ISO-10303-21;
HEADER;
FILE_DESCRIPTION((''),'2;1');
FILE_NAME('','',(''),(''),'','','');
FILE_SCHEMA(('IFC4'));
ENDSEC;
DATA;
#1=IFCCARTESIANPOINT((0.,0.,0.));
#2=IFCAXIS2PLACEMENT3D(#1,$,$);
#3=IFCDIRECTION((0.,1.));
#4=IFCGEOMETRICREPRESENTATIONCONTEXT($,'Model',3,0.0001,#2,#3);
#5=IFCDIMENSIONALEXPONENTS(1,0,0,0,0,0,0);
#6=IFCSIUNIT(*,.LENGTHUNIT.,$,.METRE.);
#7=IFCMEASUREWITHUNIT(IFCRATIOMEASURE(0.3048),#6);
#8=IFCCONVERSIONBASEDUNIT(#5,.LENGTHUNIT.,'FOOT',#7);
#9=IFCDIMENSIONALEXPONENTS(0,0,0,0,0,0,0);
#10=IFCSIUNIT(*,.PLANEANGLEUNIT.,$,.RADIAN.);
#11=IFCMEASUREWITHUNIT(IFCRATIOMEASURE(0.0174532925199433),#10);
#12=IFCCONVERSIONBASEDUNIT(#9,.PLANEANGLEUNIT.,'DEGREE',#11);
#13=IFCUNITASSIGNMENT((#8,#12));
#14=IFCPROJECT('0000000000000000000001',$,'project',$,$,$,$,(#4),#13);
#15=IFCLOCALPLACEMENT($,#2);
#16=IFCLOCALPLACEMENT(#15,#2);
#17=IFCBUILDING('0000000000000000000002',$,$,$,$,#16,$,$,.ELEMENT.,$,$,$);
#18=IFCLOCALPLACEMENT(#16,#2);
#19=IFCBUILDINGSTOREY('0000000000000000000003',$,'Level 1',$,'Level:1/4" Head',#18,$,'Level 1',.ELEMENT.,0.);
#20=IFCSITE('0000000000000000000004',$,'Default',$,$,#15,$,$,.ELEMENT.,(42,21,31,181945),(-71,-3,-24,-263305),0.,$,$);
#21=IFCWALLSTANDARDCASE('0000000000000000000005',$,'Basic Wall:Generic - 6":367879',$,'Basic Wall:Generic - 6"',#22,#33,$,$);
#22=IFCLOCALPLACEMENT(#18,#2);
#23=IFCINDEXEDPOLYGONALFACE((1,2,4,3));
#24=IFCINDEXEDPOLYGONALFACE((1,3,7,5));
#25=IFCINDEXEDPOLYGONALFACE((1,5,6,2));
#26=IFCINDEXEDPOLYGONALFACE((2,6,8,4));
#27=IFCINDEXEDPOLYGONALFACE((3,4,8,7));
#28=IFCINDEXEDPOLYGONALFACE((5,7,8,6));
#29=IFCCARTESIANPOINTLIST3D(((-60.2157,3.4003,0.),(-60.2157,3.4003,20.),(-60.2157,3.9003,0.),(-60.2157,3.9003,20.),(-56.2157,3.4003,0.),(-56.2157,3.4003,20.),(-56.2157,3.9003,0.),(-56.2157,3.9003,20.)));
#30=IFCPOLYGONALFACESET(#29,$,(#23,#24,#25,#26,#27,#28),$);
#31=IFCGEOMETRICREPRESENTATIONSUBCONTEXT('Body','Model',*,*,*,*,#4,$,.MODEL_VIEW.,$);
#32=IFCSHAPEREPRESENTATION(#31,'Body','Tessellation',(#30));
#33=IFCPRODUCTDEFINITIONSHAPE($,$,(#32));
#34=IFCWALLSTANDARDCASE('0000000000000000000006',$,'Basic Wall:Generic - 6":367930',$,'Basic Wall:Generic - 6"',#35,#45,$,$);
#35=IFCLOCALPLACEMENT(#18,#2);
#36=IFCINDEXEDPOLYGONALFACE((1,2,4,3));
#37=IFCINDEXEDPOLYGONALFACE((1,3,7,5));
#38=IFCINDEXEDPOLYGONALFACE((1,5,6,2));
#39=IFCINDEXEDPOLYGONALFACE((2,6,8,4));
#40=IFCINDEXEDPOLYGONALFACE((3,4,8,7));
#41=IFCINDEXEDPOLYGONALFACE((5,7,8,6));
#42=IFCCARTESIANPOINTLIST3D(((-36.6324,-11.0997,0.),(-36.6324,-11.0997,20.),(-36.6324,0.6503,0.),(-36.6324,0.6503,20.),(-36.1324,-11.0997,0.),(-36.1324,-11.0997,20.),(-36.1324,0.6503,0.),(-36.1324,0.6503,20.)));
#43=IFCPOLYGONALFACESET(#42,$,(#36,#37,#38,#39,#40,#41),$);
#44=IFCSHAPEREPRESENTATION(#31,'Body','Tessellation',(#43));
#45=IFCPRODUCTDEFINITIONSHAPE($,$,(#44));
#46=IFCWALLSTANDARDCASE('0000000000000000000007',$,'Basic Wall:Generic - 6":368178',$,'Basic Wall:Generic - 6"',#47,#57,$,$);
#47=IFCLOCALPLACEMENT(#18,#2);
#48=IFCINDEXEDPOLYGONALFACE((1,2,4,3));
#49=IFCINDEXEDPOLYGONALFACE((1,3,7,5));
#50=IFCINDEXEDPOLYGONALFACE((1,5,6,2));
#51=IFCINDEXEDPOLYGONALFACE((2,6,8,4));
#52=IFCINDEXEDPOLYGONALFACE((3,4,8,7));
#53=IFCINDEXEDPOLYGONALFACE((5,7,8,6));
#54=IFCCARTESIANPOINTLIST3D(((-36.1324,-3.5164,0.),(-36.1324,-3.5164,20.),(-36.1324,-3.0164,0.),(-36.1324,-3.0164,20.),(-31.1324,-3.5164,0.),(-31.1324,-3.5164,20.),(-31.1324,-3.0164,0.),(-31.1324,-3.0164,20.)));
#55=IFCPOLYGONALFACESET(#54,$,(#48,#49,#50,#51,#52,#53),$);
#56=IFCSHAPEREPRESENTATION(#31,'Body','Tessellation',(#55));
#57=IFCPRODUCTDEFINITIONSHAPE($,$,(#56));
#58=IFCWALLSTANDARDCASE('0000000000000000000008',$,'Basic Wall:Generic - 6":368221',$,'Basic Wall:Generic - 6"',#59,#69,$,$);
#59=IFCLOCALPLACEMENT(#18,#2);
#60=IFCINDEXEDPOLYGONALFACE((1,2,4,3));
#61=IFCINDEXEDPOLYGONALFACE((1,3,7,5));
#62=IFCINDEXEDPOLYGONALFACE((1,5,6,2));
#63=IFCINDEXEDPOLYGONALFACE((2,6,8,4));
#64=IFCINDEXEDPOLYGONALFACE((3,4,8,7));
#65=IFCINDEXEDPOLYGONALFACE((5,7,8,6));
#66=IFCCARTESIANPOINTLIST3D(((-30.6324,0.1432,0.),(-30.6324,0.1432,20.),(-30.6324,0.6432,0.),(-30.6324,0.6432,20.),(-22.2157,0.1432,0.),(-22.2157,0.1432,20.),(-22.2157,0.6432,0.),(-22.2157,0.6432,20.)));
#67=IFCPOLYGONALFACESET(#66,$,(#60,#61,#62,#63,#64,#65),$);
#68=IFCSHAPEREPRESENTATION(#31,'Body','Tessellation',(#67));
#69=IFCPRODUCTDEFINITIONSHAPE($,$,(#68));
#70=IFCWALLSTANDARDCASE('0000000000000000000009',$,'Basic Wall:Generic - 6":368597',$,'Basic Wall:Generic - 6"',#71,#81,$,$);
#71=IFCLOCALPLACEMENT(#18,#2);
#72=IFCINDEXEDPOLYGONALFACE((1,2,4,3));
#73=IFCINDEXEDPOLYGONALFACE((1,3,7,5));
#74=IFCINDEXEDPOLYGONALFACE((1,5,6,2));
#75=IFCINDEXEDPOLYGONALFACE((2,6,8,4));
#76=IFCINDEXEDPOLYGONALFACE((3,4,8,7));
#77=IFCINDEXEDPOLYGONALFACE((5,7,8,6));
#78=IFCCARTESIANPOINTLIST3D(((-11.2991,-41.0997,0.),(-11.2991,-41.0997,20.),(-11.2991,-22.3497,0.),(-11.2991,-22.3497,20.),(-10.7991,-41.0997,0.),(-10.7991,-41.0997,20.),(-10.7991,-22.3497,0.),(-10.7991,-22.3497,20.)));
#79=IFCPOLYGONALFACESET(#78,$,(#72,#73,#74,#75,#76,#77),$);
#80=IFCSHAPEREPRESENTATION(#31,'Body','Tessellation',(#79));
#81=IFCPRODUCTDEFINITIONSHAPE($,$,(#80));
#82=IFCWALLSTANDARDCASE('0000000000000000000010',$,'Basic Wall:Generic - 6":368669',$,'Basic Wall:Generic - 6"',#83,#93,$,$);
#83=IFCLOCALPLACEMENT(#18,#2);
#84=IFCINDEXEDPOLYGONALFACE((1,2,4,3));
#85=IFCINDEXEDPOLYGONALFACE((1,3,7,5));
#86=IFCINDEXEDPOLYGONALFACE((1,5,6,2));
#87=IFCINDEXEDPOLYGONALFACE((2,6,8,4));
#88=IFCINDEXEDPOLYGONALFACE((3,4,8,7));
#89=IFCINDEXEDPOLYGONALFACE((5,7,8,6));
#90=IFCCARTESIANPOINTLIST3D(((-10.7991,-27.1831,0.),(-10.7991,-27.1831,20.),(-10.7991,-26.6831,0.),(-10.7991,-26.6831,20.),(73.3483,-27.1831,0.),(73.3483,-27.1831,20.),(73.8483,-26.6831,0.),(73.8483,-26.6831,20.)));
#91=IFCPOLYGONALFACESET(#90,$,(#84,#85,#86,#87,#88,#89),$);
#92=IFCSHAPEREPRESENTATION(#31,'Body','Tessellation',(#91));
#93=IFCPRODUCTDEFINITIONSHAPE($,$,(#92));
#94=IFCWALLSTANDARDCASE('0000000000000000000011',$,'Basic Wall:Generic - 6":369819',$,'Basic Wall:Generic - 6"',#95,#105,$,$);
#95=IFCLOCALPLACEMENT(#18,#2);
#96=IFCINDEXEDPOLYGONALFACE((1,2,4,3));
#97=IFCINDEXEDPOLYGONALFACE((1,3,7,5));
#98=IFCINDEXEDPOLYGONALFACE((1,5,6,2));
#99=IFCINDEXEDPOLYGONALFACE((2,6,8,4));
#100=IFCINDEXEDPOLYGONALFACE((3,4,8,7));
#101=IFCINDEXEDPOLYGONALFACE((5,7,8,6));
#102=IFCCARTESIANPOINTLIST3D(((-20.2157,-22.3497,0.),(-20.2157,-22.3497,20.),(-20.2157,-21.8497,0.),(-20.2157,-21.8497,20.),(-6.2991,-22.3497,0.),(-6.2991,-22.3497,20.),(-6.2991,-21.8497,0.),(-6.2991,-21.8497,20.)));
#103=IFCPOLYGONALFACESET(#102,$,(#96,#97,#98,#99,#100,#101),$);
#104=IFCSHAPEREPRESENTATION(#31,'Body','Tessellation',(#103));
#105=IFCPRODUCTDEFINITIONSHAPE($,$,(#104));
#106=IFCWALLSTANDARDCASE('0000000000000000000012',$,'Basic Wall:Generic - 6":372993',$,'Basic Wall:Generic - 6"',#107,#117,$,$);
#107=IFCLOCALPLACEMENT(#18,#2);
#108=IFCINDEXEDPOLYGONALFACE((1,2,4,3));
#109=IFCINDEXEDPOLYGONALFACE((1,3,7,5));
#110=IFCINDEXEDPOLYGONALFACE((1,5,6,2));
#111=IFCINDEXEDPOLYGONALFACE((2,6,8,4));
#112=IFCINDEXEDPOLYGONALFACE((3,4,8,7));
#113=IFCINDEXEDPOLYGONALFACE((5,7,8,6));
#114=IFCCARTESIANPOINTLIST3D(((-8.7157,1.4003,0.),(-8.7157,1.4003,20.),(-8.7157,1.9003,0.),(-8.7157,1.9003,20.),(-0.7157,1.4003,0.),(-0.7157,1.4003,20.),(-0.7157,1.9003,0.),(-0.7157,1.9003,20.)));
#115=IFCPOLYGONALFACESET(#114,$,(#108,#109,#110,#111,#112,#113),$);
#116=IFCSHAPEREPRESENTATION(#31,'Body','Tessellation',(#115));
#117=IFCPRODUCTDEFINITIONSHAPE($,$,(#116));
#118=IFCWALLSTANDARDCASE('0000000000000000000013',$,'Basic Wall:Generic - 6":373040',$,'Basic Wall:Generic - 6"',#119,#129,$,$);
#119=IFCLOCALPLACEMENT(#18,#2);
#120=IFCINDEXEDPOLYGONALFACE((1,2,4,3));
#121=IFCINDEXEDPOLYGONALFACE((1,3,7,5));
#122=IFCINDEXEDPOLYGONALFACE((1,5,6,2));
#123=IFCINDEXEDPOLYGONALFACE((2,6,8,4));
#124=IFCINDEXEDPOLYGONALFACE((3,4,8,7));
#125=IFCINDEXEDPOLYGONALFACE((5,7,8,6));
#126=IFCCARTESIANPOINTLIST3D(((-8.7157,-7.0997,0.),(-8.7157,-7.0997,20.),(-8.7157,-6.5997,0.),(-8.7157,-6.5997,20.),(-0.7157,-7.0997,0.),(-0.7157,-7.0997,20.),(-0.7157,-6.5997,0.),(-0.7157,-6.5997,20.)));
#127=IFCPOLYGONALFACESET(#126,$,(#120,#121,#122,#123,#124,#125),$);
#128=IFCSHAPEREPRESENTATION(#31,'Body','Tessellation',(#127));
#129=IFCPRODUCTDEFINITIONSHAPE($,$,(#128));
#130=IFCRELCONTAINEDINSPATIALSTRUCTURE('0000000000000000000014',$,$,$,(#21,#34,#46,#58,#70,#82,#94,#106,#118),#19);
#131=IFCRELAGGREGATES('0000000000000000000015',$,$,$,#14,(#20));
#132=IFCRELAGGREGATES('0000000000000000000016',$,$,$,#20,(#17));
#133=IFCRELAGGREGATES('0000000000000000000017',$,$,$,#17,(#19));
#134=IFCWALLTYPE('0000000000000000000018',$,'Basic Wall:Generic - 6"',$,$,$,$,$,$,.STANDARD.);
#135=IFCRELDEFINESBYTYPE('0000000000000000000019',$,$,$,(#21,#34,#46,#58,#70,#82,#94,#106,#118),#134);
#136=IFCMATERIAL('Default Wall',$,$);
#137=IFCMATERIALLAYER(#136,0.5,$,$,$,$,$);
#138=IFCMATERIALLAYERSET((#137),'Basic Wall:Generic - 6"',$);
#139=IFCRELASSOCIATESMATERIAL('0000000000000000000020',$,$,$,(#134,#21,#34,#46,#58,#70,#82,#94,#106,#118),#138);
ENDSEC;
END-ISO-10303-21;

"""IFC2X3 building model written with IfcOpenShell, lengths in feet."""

from ifc_helpers import new_model, entity, si_unit, converted_unit, direction, frame, frame_2d, origin, place, context, subcontext, project, spatial, polyline, rectangle, outline, extrude, material, layer, layer_set, layer_usage, type_object, element, save


model = new_model("IFC2X3")

# Units and contexts
model_context = context("Model", 3, precision=0.0001, world=origin(), true_north=direction((0.0, 1.0)))
body_context = subcontext(model_context, "Body", "Model", "MODEL_VIEW")
ifc_project = project(units=[converted_unit("LENGTHUNIT", "FOOT", entity("IfcRatioMeasure", 0.3048), si_unit("LENGTHUNIT", "METRE"), dimensions=[1, 0, 0, 0, 0, 0, 0]), converted_unit("PLANEANGLEUNIT", "DEGREE", entity("IfcRatioMeasure", 0.0174532925199433), si_unit("PLANEANGLEUNIT", "RADIAN"), dimensions=[0, 0, 0, 0, 0, 0, 0])], contexts=[model_context])

# Site, building, storey
site_placement = place(None, origin())
site = spatial("IfcSite", under=ifc_project, at=site_placement, Name="Default", CompositionType="ELEMENT", RefLatitude=(42, 21, 31, 181945), RefLongitude=(-71, -3, -24, -263305), RefElevation=0.0)
building_placement = place(site_placement, origin())
building = spatial("IfcBuilding", under=site, at=building_placement, CompositionType="ELEMENT")
storey_placement = place(building_placement, origin())
storey = spatial("IfcBuildingStorey", under=building, at=storey_placement, Name="Level 1", ObjectType="Level:1/4\" Head", LongName="Level 1", CompositionType="ELEMENT", Elevation=0.0)

# Walls
ifc_material = material(Name="Default Wall")
ifc_layer_1 = layer(ifc_material, 0.5)
ifc_layer_set_1 = layer_set([ifc_layer_1], Name="Basic Wall:Generic - 6\"")
wall_type_1 = type_object("IfcWallType", Name="Basic Wall:Generic - 6\"", PredefinedType="STANDARD", material=ifc_layer_set_1)
ifc_layer_usage_1 = layer_usage(ifc_layer_set_1, "AXIS2", "NEGATIVE", 0.25)
wall_1_placement = place(storey_placement, frame((-60.2157, 3.6503, 0.0)))
element("IfcWallStandardCase", 1, at=wall_1_placement, inside=storey, type_object=wall_type_1, material=ifc_layer_usage_1, Name="Basic Wall:Generic - 6\":367879", ObjectType="Basic Wall:Generic - 6\"", context=body_context, shape_type="SweptSolid", body=[
    extrude(rectangle(XDim=4.0, YDim=0.5, at=frame_2d((2.0, 0.0), x_axis=(-1.0, 0.0))), origin(), (0.0, 0.0, 1.0), 20.0),
])
ifc_layer_usage_2 = layer_usage(ifc_layer_set_1, "AXIS2", "NEGATIVE", 0.25)
wall_2_placement = place(storey_placement, frame((-36.3824, -11.0997, 0.0), z_axis=(0.0, 0.0, 1.0), x_axis=(0.0, 1.0, 0.0)))
element("IfcWallStandardCase", 2, at=wall_2_placement, inside=storey, type_object=wall_type_1, material=ifc_layer_usage_2, Name="Basic Wall:Generic - 6\":367930", ObjectType="Basic Wall:Generic - 6\"", context=body_context, shape_type="SweptSolid", body=[
    extrude(rectangle(XDim=11.75, YDim=0.5, at=frame_2d((5.875, 0.0), x_axis=(-1.0, 0.0))), origin(), (0.0, 0.0, 1.0), 20.0),
])
ifc_layer_usage_3 = layer_usage(ifc_layer_set_1, "AXIS2", "NEGATIVE", 0.25)
wall_3_placement = place(storey_placement, frame((-31.1324, -3.2664, 0.0), z_axis=(0.0, 0.0, 1.0), x_axis=(-1.0, 0.0, 0.0)))
element("IfcWallStandardCase", 3, at=wall_3_placement, inside=storey, type_object=wall_type_1, material=ifc_layer_usage_3, Name="Basic Wall:Generic - 6\":368178", ObjectType="Basic Wall:Generic - 6\"", context=body_context, shape_type="SweptSolid", body=[
    extrude(rectangle(XDim=5.0, YDim=0.5, at=frame_2d((2.5, 0.0), x_axis=(-1.0, 0.0))), origin(), (0.0, 0.0, 1.0), 20.0),
])
ifc_layer_usage_4 = layer_usage(ifc_layer_set_1, "AXIS2", "NEGATIVE", 0.25)
wall_4_placement = place(storey_placement, frame((-30.6324, 0.3932, 0.0)))
element("IfcWallStandardCase", 4, at=wall_4_placement, inside=storey, type_object=wall_type_1, material=ifc_layer_usage_4, Name="Basic Wall:Generic - 6\":368221", ObjectType="Basic Wall:Generic - 6\"", context=body_context, shape_type="SweptSolid", body=[
    extrude(rectangle(XDim=8.4167, YDim=0.5, at=frame_2d((4.2083, 0.0), x_axis=(-1.0, 0.0))), origin(), (0.0, 0.0, 1.0), 20.0),
])
ifc_layer_usage_5 = layer_usage(ifc_layer_set_1, "AXIS2", "NEGATIVE", 0.25)
wall_5_placement = place(storey_placement, frame((-11.0491, -41.0997, 0.0), z_axis=(0.0, 0.0, 1.0), x_axis=(0.0, 1.0, 0.0)))
element("IfcWallStandardCase", 5, at=wall_5_placement, inside=storey, type_object=wall_type_1, material=ifc_layer_usage_5, Name="Basic Wall:Generic - 6\":368597", ObjectType="Basic Wall:Generic - 6\"", context=body_context, shape_type="SweptSolid", body=[
    extrude(rectangle(XDim=18.75, YDim=0.5, at=frame_2d((9.375, 0.0), x_axis=(-1.0, 0.0))), origin(), (0.0, 0.0, 1.0), 20.0),
])
ifc_layer_usage_6 = layer_usage(ifc_layer_set_1, "AXIS2", "NEGATIVE", 0.25)
wall_6_placement = place(storey_placement, frame((-10.7991, -26.9331, 0.0)))
element("IfcWallStandardCase", 6, at=wall_6_placement, inside=storey, type_object=wall_type_1, material=ifc_layer_usage_6, Name="Basic Wall:Generic - 6\":368669", ObjectType="Basic Wall:Generic - 6\"", context=body_context, shape_type="SweptSolid", body=[
    extrude(outline(polyline([(84.1474, -0.25), (84.6474, 0.25), (0.0, 0.25), (0.0, -0.25), (84.1474, -0.25)])), origin(), (0.0, 0.0, 1.0), 20.0),
])
ifc_layer_usage_7 = layer_usage(ifc_layer_set_1, "AXIS2", "NEGATIVE", 0.25)
wall_7_placement = place(storey_placement, frame((-20.2157, -22.0997, 0.0)))
element("IfcWallStandardCase", 7, at=wall_7_placement, inside=storey, type_object=wall_type_1, material=ifc_layer_usage_7, Name="Basic Wall:Generic - 6\":369819", ObjectType="Basic Wall:Generic - 6\"", context=body_context, shape_type="SweptSolid", body=[
    extrude(rectangle(XDim=13.9167, YDim=0.5, at=frame_2d((6.9583, 0.0), x_axis=(-1.0, 0.0))), origin(), (0.0, 0.0, 1.0), 20.0),
])
ifc_layer_usage_8 = layer_usage(ifc_layer_set_1, "AXIS2", "NEGATIVE", 0.25)
wall_8_placement = place(storey_placement, frame((-8.7157, 1.6503, 0.0)))
element("IfcWallStandardCase", 8, at=wall_8_placement, inside=storey, type_object=wall_type_1, material=ifc_layer_usage_8, Name="Basic Wall:Generic - 6\":372993", ObjectType="Basic Wall:Generic - 6\"", context=body_context, shape_type="SweptSolid", body=[
    extrude(rectangle(XDim=8.0, YDim=0.5, at=frame_2d((4.0, 0.0), x_axis=(-1.0, 0.0))), origin(), (0.0, 0.0, 1.0), 20.0),
])
ifc_layer_usage_9 = layer_usage(ifc_layer_set_1, "AXIS2", "NEGATIVE", 0.25)
wall_9_placement = place(storey_placement, frame((-8.7157, -6.8497, 0.0)))
element("IfcWallStandardCase", 9, at=wall_9_placement, inside=storey, type_object=wall_type_1, material=ifc_layer_usage_9, Name="Basic Wall:Generic - 6\":373040", ObjectType="Basic Wall:Generic - 6\"", context=body_context, shape_type="SweptSolid", body=[
    extrude(rectangle(XDim=8.0, YDim=0.5, at=frame_2d((4.0, 0.0), x_axis=(-1.0, 0.0))), origin(), (0.0, 0.0, 1.0), 20.0),
])

save(model, "model.ifc")
